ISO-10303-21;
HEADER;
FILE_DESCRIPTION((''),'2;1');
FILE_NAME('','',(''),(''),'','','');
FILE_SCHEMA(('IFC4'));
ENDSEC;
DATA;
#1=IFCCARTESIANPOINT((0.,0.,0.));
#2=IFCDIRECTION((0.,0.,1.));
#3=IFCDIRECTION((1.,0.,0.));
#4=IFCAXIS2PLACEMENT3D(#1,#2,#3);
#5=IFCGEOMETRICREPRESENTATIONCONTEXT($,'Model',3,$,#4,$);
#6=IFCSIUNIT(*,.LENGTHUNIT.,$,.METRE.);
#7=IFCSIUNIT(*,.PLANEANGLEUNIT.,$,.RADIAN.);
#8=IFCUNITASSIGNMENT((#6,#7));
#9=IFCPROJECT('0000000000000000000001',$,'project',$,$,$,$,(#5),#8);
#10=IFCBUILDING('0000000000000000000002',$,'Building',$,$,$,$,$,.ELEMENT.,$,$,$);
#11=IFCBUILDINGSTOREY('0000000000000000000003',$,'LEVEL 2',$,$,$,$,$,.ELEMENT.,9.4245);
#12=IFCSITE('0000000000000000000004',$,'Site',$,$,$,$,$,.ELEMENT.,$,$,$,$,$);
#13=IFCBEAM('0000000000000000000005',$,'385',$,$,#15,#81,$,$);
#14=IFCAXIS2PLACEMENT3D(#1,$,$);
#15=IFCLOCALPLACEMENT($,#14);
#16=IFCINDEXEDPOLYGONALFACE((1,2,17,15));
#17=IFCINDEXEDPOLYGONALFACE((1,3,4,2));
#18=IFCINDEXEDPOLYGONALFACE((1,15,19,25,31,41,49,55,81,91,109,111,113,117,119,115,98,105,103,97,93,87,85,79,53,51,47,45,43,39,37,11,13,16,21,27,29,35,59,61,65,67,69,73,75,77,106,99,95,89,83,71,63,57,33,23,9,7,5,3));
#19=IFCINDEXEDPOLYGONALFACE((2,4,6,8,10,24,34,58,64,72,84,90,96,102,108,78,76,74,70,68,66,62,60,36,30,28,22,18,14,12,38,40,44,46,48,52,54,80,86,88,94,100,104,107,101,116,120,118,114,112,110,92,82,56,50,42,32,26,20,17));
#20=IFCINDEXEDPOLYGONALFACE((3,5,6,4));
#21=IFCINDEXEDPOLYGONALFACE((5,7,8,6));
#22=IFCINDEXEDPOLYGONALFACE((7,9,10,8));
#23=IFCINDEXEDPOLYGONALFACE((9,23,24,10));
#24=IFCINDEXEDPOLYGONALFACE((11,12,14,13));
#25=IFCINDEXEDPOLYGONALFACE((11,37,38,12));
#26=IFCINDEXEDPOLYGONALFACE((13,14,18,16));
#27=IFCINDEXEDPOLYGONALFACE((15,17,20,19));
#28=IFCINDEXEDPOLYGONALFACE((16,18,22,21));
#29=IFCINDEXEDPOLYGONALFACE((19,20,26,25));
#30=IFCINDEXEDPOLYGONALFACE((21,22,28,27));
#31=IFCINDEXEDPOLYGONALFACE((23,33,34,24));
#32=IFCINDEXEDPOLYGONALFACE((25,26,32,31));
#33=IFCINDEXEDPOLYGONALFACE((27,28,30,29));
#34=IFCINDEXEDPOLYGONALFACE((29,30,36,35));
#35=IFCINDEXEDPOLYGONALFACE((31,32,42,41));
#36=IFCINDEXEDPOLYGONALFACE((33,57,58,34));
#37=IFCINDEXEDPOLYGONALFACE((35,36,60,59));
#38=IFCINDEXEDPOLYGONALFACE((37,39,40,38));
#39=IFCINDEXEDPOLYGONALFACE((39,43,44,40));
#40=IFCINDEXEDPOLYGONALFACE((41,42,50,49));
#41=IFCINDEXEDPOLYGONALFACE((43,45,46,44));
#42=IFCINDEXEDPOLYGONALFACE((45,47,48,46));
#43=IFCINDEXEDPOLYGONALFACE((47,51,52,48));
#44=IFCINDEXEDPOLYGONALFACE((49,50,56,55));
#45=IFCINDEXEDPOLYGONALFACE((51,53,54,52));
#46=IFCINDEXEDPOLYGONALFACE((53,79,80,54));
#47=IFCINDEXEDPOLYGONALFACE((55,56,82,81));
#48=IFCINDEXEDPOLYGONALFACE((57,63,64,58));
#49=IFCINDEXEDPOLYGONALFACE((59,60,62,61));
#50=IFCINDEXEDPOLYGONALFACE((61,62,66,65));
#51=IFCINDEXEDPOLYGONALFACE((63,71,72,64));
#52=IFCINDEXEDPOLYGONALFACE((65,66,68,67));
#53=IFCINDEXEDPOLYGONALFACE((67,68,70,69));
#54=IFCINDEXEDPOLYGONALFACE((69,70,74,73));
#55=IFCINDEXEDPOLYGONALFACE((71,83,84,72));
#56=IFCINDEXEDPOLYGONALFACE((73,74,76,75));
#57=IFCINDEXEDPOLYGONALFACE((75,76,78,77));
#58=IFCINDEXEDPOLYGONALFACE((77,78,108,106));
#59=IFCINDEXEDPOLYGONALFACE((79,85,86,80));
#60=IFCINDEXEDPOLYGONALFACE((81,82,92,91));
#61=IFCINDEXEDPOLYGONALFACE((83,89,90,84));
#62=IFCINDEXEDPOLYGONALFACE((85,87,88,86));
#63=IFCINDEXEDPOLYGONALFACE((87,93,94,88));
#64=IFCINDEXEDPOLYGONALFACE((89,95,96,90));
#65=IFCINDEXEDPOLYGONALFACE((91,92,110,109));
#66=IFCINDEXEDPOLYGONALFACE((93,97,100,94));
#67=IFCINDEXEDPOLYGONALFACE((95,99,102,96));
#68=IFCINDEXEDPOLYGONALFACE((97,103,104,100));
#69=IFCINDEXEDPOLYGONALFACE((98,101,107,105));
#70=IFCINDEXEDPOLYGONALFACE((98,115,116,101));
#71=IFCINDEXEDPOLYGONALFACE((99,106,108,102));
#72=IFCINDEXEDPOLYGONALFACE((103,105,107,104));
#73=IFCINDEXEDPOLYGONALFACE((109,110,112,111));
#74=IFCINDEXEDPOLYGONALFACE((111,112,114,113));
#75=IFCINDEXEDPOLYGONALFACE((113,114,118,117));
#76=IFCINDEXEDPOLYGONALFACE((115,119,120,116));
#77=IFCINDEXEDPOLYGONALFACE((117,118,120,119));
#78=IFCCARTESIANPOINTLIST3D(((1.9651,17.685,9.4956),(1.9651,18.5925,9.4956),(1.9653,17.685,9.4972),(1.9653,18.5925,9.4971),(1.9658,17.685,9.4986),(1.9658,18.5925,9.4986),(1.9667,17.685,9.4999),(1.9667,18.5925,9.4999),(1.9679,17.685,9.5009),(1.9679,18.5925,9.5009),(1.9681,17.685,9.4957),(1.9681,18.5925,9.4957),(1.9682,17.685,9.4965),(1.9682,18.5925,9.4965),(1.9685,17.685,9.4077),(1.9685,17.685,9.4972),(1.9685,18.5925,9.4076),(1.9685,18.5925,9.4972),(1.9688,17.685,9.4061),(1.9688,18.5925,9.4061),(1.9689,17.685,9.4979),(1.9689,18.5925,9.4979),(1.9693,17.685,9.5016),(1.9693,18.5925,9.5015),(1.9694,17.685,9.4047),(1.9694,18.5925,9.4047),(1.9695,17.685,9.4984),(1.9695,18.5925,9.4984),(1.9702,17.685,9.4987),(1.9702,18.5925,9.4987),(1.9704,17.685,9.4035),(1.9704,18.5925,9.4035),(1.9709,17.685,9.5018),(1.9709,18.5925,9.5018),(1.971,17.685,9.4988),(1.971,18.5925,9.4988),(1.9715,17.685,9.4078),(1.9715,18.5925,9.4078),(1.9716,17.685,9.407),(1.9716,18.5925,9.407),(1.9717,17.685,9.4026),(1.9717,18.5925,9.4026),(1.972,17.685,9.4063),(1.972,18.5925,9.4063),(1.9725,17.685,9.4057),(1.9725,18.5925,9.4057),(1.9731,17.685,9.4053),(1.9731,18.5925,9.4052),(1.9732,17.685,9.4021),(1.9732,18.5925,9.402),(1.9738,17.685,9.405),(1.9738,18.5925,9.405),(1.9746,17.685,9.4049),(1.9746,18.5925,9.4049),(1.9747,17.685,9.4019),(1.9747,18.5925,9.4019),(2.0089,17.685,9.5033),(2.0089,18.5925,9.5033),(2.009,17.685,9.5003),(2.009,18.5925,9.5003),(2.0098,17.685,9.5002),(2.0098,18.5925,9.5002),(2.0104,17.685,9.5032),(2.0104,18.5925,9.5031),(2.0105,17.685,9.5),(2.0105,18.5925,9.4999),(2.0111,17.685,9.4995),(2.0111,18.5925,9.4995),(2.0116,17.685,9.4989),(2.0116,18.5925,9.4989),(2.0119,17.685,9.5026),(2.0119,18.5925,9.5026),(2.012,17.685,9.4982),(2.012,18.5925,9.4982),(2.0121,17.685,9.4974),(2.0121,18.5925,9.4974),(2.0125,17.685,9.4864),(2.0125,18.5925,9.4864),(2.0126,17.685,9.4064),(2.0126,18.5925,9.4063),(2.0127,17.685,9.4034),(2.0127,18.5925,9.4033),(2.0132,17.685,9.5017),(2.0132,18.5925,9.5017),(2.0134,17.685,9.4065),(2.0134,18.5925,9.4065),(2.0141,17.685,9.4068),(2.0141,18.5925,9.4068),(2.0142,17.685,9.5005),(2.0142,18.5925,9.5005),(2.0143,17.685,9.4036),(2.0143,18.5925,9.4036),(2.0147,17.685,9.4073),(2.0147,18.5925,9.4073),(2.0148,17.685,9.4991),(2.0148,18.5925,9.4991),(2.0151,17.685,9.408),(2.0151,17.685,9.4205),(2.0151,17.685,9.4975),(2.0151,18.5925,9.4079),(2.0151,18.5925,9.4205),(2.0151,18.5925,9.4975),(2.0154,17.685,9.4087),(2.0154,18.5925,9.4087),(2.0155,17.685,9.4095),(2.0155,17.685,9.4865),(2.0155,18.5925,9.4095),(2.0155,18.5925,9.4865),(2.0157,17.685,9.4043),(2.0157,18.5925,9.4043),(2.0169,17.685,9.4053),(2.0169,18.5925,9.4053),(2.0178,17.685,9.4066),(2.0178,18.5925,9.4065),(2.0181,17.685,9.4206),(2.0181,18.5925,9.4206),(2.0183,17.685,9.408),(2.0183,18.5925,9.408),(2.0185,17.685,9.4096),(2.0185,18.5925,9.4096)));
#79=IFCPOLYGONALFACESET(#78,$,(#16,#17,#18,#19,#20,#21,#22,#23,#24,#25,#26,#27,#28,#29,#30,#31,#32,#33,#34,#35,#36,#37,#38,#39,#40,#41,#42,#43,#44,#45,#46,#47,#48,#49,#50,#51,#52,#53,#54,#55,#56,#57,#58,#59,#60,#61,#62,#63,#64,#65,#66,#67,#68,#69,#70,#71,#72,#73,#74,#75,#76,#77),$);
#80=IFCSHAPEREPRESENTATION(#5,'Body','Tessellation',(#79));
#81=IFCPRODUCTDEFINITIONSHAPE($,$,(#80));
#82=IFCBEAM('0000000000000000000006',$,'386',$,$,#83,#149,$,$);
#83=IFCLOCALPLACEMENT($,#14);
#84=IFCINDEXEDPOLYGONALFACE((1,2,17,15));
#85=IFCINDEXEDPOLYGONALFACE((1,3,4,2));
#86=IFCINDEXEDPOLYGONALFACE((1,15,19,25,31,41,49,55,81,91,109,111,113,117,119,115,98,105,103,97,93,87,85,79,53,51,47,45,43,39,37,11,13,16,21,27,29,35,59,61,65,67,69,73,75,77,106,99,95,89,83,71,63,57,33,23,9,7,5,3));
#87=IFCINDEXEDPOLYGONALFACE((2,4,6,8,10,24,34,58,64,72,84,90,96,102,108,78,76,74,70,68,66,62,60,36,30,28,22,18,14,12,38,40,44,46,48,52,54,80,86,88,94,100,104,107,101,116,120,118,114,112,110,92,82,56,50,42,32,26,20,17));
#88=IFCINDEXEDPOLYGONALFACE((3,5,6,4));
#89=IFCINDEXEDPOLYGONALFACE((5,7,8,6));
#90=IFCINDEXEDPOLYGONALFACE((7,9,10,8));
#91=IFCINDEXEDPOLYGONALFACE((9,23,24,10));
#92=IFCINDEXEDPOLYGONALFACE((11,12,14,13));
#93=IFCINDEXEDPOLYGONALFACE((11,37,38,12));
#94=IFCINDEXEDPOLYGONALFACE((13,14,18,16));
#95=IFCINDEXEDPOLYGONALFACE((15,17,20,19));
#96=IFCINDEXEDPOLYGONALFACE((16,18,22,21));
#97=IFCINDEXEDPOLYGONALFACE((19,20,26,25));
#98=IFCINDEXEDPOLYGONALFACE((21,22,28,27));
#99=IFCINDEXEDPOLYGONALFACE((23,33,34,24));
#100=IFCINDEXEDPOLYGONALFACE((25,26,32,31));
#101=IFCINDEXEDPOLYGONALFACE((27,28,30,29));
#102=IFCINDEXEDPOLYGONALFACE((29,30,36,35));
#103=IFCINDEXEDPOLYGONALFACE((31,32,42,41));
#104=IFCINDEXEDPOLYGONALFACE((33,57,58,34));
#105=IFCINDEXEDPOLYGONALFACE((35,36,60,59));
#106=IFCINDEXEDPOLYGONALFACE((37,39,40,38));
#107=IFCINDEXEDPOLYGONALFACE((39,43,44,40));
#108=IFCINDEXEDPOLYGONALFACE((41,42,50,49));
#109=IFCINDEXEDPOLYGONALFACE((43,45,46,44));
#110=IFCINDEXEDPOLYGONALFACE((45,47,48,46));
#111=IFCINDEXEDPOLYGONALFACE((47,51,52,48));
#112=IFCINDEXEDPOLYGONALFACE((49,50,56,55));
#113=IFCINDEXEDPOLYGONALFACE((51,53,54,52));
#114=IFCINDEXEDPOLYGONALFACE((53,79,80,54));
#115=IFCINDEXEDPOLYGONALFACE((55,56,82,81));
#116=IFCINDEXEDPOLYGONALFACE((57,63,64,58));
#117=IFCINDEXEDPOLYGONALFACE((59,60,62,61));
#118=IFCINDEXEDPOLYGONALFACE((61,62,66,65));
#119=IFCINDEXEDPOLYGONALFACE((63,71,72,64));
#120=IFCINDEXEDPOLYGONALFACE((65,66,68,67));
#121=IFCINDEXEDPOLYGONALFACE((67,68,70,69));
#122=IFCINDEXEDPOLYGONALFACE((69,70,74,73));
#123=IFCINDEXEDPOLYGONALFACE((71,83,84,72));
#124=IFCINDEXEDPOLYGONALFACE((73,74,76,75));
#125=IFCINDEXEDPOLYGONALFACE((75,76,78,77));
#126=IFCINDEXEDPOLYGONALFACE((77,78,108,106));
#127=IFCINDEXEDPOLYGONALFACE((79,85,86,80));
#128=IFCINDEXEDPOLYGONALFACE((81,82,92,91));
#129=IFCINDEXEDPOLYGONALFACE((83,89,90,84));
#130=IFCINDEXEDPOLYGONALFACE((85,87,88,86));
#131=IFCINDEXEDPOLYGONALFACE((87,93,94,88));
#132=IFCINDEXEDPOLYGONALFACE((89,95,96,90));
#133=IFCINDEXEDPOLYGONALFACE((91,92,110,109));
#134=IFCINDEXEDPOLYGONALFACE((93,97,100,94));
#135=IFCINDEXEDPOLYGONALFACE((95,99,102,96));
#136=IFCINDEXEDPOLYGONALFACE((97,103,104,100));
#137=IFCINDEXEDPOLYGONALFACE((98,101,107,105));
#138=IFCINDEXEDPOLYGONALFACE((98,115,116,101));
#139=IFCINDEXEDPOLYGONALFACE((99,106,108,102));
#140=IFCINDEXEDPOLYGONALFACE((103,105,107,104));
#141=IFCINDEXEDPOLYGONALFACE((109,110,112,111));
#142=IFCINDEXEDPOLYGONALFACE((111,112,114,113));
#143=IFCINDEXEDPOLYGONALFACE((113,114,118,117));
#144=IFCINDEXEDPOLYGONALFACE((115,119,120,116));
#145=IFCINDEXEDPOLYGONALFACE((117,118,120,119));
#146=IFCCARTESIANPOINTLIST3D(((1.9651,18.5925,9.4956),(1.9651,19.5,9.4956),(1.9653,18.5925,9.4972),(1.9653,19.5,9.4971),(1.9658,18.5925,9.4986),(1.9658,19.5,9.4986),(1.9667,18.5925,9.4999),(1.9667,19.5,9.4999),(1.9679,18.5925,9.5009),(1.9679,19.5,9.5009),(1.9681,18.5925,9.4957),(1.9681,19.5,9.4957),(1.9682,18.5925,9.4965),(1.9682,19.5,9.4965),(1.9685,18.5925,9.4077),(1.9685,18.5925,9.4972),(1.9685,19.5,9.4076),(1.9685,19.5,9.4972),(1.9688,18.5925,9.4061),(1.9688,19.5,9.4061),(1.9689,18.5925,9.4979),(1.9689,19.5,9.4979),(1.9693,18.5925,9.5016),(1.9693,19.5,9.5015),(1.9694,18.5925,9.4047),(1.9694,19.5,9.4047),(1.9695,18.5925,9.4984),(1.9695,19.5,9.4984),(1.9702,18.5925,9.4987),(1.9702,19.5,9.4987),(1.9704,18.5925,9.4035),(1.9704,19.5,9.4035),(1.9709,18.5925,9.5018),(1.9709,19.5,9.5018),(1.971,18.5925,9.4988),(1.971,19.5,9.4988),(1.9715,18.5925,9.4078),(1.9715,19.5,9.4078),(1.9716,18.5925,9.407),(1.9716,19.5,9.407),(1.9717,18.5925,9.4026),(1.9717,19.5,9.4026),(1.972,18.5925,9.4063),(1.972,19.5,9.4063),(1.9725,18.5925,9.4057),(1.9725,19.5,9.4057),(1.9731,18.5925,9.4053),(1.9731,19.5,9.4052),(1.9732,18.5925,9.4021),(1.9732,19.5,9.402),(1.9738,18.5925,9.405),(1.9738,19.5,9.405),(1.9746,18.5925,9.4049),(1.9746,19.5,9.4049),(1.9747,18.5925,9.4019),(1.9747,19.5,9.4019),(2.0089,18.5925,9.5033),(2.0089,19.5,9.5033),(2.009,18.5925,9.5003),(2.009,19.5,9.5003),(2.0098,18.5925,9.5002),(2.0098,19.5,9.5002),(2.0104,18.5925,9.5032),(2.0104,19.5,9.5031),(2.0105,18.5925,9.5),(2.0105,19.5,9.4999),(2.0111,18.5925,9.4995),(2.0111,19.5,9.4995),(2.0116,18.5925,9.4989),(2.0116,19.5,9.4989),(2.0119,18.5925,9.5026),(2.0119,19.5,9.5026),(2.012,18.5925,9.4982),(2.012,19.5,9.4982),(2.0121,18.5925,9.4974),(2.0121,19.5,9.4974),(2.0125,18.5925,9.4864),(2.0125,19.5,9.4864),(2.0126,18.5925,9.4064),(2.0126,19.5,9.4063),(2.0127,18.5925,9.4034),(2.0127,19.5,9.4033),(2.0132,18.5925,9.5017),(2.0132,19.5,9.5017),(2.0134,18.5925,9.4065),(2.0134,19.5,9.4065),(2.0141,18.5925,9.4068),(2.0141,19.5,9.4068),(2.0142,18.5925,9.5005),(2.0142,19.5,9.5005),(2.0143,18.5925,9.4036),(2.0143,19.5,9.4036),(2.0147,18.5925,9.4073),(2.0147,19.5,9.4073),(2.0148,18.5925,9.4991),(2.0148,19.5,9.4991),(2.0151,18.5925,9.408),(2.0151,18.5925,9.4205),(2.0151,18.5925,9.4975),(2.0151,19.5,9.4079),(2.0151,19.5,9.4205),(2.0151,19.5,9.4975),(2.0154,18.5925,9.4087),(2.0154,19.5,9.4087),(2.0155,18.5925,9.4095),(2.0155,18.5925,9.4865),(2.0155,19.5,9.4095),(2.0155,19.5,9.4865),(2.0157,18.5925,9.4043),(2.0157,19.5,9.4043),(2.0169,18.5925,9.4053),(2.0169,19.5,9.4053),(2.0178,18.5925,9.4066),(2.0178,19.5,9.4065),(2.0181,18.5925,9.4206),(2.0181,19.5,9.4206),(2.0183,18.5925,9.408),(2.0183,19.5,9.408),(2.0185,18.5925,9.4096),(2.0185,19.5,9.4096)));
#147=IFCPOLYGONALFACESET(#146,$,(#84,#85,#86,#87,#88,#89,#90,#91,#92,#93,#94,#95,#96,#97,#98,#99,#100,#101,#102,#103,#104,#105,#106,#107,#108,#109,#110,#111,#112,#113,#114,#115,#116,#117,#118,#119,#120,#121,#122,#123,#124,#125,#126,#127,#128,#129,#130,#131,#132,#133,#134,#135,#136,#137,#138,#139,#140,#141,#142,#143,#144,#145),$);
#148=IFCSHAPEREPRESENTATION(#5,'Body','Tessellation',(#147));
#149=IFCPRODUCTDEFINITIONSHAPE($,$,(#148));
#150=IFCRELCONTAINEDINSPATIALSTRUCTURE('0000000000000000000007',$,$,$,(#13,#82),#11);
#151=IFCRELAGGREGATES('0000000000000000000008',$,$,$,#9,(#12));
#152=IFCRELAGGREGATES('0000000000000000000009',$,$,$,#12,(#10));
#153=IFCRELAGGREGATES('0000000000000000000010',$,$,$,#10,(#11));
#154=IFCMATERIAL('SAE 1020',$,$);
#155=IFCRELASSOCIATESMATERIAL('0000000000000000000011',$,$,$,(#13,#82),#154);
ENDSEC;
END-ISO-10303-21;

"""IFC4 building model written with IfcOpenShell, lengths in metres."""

from ifc_helpers import new_model, si_unit, frame, origin_with_axes, origin_2d_with_axis, place, context, project, spatial, c_section, extrude, material, material_profile, profile_set, profile_usage, element, save


model = new_model("IFC4")

# Units and contexts
model_context = context("Model", 3, world=origin_with_axes())
ifc_project = project(units=[si_unit("LENGTHUNIT", "METRE"), si_unit("PLANEANGLEUNIT", "RADIAN")], contexts=[model_context])

# Site, building, storey
site = spatial("IfcSite", under=ifc_project, Name="Site", CompositionType="ELEMENT")
building = spatial("IfcBuilding", under=site, Name="Building", CompositionType="ELEMENT")
storey = spatial("IfcBuildingStorey", under=building, Name="LEVEL 2", CompositionType="ELEMENT", Elevation=9.4245)

# Beams
ifc_material = material(Name="SAE 1020")
ifc_material_profile_1 = material_profile(ifc_material, c_section(Depth=0.1, Width=0.05, WallThickness=0.003, Girth=0.017, InternalFilletRadius=0.003, at=origin_2d_with_axis()))
ifc_profile_set_1 = profile_set([ifc_material_profile_1])
ifc_profile_usage_1 = profile_usage(ifc_profile_set_1, cardinal=10)
beam_1_placement = place(None, frame((1.9918, 17.685, 9.4526), z_axis=(0.0, 1.0, -0.00003), x_axis=(0.999256, 0.000001, 0.038562)))
element("IfcBeam", 1, at=beam_1_placement, inside=storey, material=ifc_profile_usage_1, Name="385", context=model_context, shape_type="SweptSolid", body=[
    extrude(c_section(Depth=0.1, Width=0.05, WallThickness=0.003, Girth=0.017, InternalFilletRadius=0.003, at=origin_2d_with_axis()), origin_with_axes(), (0.0, 0.0, 1.0), 0.9075),
])
ifc_material_profile_2 = material_profile(ifc_material, c_section(Depth=0.1, Width=0.05, WallThickness=0.003, Girth=0.017, InternalFilletRadius=0.003, at=origin_2d_with_axis()))
ifc_profile_set_2 = profile_set([ifc_material_profile_2])
ifc_profile_usage_2 = profile_usage(ifc_profile_set_2, cardinal=10)
beam_2_placement = place(None, frame((1.9918, 18.5925, 9.4526), z_axis=(0.0, 1.0, -0.00003), x_axis=(0.999256, 0.000001, 0.038562)))
element("IfcBeam", 2, at=beam_2_placement, inside=storey, material=ifc_profile_usage_2, Name="386", context=model_context, shape_type="SweptSolid", body=[
    extrude(c_section(Depth=0.1, Width=0.05, WallThickness=0.003, Girth=0.017, InternalFilletRadius=0.003, at=origin_2d_with_axis()), origin_with_axes(), (0.0, 0.0, 1.0), 0.9075),
])

save(model, "model.ifc")
